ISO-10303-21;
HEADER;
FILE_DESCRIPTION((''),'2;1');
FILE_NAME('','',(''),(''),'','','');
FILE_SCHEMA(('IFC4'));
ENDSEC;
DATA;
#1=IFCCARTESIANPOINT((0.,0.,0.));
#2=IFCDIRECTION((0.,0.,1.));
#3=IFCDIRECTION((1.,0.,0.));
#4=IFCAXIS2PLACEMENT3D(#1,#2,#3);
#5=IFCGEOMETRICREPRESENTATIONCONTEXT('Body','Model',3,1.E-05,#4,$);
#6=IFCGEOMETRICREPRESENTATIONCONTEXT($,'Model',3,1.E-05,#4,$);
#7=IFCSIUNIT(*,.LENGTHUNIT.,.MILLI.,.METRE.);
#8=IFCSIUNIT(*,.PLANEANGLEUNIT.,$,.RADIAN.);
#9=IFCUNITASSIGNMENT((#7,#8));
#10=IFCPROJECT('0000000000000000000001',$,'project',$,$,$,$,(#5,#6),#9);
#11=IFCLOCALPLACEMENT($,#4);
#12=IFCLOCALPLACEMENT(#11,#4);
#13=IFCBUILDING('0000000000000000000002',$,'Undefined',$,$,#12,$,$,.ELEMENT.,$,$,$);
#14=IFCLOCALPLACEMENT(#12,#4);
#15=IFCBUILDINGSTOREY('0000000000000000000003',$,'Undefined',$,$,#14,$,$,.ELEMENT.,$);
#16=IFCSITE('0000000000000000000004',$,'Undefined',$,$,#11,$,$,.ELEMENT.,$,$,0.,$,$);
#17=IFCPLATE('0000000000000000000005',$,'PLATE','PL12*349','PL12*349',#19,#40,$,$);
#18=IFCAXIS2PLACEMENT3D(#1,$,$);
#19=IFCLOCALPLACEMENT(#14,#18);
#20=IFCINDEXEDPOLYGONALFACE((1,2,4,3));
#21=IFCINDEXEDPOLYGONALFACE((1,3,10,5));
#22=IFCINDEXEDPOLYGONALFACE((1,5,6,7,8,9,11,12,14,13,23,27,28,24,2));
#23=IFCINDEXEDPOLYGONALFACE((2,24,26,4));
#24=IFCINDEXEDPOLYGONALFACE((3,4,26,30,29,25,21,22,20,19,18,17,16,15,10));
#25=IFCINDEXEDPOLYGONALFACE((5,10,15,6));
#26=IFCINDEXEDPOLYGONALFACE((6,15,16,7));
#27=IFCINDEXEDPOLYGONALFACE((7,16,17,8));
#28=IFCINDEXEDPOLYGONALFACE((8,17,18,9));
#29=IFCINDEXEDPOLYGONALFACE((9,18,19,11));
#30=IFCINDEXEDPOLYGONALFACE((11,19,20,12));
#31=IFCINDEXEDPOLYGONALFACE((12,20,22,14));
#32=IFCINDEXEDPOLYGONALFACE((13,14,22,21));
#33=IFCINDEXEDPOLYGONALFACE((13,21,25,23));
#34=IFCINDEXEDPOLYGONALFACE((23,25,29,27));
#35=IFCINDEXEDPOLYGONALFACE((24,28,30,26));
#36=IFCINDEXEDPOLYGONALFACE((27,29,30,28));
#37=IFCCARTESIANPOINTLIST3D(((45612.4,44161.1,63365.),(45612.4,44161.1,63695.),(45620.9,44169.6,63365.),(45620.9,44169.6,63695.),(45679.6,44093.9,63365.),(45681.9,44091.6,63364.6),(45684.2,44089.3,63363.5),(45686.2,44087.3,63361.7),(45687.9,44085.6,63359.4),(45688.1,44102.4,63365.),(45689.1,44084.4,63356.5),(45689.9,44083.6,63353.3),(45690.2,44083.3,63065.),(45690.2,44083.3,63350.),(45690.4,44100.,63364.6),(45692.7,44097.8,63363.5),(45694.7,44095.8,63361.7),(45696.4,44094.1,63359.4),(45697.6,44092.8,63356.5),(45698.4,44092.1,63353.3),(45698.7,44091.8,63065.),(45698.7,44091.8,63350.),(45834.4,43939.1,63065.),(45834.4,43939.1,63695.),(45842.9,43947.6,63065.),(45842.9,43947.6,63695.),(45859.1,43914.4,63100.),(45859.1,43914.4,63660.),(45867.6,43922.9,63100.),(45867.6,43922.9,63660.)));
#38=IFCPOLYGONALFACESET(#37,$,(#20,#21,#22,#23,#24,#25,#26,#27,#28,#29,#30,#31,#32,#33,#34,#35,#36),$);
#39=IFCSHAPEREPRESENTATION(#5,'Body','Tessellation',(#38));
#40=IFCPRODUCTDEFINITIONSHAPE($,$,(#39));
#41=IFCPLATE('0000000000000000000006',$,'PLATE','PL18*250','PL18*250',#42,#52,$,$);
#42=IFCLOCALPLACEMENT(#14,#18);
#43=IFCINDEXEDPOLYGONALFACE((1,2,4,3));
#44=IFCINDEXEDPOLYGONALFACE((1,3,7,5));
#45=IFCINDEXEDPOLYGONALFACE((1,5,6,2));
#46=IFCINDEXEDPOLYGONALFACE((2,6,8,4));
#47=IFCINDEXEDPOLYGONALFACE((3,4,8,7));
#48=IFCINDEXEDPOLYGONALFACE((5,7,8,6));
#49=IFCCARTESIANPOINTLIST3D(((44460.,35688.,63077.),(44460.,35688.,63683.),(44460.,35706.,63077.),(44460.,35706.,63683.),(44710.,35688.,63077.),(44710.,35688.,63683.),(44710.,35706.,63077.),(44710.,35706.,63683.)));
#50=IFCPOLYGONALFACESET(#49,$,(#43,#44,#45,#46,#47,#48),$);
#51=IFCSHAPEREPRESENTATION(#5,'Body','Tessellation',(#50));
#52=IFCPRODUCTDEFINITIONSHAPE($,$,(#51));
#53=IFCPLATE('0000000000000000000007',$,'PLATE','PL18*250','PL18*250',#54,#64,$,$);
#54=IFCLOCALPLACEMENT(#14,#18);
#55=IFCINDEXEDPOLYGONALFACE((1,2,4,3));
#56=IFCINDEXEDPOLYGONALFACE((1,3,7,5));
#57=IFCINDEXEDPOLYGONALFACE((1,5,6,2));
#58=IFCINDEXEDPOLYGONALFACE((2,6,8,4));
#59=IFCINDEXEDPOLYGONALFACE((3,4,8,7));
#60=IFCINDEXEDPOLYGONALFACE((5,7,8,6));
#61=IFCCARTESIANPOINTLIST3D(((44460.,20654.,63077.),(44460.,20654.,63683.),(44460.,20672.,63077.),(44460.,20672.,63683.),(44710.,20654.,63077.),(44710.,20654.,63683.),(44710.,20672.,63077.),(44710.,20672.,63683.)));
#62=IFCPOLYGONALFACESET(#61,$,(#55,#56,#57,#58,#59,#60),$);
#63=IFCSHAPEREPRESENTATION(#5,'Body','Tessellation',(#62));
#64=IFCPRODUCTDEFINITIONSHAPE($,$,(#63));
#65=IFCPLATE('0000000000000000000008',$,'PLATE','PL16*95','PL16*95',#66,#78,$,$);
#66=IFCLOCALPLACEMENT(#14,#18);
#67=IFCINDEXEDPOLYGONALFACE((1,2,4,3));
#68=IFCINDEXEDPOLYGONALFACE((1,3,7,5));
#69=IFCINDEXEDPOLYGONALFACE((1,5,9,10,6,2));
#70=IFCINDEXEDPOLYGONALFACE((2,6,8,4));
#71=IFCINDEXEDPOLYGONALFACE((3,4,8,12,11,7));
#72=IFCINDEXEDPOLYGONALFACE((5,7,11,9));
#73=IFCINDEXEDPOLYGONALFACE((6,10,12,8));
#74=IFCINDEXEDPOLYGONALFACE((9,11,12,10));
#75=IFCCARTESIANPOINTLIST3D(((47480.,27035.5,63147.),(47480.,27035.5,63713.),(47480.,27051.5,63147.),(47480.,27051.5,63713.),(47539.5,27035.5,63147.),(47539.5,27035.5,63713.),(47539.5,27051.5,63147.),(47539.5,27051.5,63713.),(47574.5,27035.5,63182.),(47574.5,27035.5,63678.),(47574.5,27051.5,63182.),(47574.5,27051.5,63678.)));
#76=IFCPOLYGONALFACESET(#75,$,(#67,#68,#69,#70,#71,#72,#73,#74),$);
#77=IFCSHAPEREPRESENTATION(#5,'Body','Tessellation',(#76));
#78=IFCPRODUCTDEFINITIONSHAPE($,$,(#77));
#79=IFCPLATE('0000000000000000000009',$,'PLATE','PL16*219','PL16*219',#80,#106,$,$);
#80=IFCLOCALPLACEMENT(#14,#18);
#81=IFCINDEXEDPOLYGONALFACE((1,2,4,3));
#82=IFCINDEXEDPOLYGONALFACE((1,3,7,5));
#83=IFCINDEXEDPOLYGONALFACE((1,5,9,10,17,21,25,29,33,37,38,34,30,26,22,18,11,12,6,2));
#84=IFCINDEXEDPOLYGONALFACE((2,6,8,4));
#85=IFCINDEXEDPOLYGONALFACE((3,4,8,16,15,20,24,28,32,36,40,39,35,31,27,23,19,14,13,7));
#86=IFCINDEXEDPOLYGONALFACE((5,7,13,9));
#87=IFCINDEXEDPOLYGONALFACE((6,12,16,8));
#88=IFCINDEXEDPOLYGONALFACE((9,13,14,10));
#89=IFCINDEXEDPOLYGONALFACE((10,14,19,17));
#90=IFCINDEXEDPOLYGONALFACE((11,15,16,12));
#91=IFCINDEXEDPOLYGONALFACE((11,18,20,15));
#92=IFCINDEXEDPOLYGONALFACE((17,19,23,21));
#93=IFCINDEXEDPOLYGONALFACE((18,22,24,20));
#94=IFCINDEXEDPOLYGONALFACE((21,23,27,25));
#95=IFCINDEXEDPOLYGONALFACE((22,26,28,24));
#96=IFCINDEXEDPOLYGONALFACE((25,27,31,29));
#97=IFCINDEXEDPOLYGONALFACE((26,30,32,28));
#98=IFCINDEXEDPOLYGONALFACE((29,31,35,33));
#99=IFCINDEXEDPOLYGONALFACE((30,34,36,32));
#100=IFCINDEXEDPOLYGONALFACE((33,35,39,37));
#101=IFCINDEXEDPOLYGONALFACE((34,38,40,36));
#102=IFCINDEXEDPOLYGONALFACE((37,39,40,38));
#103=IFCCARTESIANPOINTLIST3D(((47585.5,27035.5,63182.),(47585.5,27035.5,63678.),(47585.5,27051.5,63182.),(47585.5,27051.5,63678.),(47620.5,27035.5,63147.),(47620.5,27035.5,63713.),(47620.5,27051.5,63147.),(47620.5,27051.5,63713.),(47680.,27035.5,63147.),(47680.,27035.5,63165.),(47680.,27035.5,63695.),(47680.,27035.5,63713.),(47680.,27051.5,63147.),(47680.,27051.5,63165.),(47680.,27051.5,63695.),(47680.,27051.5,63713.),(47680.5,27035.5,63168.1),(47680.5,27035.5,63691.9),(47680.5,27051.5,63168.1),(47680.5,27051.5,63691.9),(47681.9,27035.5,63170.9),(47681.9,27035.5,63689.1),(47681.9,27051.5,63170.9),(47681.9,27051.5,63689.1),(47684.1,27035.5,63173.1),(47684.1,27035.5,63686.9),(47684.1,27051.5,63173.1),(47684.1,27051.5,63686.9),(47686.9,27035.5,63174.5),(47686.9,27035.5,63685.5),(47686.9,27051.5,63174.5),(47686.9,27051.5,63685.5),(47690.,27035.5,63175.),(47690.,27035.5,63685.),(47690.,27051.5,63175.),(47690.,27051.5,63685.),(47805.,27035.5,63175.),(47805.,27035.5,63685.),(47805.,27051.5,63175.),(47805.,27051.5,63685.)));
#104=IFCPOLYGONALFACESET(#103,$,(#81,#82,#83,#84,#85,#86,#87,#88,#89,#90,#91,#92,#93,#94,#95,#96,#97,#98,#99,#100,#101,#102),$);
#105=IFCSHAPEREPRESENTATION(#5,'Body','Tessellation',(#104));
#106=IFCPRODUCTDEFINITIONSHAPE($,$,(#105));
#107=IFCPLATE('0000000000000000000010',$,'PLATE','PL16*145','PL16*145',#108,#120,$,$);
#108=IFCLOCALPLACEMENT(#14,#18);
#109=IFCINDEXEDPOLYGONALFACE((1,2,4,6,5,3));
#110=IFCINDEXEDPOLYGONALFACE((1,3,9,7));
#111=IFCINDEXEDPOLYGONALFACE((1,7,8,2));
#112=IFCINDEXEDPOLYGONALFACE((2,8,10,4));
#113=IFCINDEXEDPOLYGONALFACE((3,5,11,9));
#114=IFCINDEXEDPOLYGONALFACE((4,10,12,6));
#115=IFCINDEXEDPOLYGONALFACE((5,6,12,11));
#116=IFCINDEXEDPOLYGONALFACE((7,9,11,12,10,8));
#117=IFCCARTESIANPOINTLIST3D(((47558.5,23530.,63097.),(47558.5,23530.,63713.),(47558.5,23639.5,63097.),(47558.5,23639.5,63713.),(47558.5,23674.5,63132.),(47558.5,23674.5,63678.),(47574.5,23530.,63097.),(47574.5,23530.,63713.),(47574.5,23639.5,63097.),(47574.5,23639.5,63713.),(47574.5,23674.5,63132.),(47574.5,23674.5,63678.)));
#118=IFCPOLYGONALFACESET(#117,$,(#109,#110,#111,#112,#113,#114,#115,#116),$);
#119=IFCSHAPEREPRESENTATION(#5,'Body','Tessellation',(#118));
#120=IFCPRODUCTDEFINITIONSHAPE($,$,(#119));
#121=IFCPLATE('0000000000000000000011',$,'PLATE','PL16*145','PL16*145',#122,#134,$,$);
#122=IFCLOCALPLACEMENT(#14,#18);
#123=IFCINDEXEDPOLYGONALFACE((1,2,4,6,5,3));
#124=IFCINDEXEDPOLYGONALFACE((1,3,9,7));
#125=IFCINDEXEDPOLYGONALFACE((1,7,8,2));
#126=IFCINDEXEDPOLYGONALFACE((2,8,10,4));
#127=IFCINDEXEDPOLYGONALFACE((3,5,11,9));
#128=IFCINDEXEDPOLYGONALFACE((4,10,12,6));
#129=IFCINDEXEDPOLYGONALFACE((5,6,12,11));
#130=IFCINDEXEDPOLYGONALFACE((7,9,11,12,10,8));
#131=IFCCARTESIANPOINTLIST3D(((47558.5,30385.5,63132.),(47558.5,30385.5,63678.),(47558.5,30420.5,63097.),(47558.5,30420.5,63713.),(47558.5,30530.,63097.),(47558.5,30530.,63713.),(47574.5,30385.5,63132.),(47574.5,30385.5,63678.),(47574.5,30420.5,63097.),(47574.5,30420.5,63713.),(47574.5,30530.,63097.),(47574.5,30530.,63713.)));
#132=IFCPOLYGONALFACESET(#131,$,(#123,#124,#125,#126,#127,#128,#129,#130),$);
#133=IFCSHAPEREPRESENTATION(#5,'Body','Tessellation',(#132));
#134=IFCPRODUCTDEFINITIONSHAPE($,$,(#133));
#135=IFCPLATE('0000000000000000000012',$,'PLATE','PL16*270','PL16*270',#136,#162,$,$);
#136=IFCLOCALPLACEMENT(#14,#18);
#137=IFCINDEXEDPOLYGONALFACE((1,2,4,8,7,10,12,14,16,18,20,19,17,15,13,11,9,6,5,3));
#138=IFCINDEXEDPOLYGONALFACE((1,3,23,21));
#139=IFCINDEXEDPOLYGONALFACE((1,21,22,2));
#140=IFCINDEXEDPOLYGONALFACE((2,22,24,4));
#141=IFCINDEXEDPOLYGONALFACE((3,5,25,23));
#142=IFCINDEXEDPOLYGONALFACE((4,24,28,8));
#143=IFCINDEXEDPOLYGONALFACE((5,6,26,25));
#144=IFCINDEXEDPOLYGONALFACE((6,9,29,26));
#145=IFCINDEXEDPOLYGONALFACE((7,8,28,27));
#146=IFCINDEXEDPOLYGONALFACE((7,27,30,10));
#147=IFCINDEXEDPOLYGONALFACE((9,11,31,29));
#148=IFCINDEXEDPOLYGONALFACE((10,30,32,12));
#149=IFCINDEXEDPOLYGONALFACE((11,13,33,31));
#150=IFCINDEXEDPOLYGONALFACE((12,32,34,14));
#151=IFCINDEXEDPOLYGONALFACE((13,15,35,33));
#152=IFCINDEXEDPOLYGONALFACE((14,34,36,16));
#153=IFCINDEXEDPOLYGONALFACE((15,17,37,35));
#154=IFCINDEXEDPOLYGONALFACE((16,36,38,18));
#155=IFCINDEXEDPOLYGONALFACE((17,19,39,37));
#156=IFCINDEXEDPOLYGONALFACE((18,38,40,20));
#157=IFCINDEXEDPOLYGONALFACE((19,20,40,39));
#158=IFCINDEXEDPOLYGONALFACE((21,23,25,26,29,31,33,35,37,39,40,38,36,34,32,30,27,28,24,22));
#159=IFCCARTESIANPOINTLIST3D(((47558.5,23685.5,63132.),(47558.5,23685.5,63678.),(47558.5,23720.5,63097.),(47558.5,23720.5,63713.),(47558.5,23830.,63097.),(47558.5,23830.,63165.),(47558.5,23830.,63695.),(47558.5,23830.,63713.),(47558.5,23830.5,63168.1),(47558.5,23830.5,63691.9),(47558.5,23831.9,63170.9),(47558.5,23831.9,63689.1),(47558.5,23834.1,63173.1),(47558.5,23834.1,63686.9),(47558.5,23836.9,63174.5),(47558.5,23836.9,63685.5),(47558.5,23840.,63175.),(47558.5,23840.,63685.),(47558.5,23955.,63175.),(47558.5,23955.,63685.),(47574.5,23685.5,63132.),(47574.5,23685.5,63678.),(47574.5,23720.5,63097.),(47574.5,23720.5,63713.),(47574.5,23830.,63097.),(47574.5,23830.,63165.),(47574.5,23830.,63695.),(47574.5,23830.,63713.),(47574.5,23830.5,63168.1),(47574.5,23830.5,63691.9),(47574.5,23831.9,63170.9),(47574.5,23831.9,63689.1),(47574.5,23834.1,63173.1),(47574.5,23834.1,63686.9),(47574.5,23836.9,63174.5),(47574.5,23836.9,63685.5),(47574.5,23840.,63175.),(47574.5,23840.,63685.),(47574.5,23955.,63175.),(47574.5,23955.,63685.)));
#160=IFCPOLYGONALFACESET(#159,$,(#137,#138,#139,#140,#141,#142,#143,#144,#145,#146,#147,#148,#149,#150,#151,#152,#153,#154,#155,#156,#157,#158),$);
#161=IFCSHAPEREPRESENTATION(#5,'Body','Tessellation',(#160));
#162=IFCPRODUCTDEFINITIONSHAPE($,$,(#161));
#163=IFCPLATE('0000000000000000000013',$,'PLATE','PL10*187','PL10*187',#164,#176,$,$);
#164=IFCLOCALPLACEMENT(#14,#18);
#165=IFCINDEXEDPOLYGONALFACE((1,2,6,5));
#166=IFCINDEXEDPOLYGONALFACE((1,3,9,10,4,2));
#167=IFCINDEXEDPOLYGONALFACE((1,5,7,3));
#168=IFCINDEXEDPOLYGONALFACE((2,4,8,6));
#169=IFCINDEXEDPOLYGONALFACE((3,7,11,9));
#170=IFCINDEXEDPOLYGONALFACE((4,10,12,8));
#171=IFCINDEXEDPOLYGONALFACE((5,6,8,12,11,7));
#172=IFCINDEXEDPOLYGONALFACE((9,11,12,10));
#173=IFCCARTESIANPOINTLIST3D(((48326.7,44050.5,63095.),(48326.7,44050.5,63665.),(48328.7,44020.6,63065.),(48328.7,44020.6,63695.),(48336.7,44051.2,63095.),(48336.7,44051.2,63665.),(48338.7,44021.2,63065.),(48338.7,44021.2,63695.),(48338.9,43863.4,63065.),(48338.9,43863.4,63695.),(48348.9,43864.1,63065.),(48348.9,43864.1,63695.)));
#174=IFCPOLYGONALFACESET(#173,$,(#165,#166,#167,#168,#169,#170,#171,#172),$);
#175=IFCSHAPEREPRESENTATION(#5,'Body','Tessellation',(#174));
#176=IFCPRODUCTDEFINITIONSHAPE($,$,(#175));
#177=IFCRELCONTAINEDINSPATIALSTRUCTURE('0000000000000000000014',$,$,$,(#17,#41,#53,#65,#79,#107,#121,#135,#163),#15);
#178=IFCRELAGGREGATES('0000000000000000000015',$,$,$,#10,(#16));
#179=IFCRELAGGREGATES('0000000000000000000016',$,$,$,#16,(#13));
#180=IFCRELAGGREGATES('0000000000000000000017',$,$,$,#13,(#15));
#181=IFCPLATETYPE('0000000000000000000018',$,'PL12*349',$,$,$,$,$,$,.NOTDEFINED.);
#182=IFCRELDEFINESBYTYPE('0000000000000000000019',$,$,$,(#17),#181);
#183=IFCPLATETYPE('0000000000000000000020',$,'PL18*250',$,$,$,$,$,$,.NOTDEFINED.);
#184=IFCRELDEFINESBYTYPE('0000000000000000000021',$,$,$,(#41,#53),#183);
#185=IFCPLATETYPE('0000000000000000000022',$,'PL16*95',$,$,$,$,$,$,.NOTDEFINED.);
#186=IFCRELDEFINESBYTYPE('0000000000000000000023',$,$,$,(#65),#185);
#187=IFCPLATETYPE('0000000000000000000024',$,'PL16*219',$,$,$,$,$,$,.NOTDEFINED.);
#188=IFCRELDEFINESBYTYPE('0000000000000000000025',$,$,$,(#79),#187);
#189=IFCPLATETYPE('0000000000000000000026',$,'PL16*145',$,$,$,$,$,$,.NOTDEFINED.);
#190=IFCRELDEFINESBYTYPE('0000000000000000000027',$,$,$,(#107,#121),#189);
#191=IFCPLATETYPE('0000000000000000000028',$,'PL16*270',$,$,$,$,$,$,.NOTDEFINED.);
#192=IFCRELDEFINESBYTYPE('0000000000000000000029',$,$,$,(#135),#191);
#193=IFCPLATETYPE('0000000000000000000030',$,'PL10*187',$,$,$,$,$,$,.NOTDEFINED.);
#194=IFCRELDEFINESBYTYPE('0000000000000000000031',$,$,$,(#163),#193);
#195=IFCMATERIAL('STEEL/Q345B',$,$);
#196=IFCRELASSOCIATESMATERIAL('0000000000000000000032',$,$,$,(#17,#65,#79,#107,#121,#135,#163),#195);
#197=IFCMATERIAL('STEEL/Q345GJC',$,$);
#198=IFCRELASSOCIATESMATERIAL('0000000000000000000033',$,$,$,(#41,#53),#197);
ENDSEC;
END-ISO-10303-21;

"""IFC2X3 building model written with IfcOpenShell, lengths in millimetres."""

from ifc_helpers import new_model, si_unit, frame, origin_with_axes, place, context, project, spatial, polyline, outline, extrude, material, type_object, element, save


model = new_model("IFC2X3")

# Units and contexts
model_context_1 = context("Model", 3, precision=1e-05, world=origin_with_axes(), identifier="Body")
model_context_2 = context("Model", 3, precision=1e-05, world=origin_with_axes())
ifc_project = project(units=[si_unit("LENGTHUNIT", "METRE", prefix="MILLI"), si_unit("PLANEANGLEUNIT", "RADIAN")], contexts=[model_context_1, model_context_2])

# Site, building, storey
site_placement = place(None, origin_with_axes())
site = spatial("IfcSite", under=ifc_project, at=site_placement, Name="Undefined", CompositionType="ELEMENT", RefElevation=0.0)
building_placement = place(site_placement, origin_with_axes())
building = spatial("IfcBuilding", under=site, at=building_placement, Name="Undefined", CompositionType="ELEMENT")
storey_placement = place(building_placement, origin_with_axes())
storey = spatial("IfcBuildingStorey", under=building, at=storey_placement, Name="Undefined", CompositionType="ELEMENT")

# Shared definitions
ifc_material_1 = material(Name="STEEL/Q345B")
ifc_material_2 = material(Name="STEEL/Q345GJC")

# Plates
plate_type_1 = type_object("IfcPlateType", Name="PL12*349", PredefinedType="NOTDEFINED")
plate_1_placement = place(storey_placement, frame((45616.6, 44165.4, 63695.0), z_axis=(-0.707107, -0.707107, 0.0), x_axis=(0.0, 0.0, -1.0)))
element("IfcPlate", 1, at=plate_1_placement, inside=storey, type_object=plate_type_1, material=ifc_material_1, Name="PLATE", Description="PL12*349", ObjectType="PL12*349", context=model_context_1, shape_type="SweptSolid", body=[
    extrude(outline(polyline([(0.0, 0.0), (330.0, 0.0), (330.0, 95.0), (330.4, 98.4), (331.5, 101.5), (333.3, 104.4), (335.6, 106.8), (338.5, 108.5), (341.7, 109.7), (345.0, 110.0), (630.0, 110.0), (630.0, 313.9), (595.0, 348.9), (35.0, 348.9), (0.0, 313.9), (0.0, 0.0)])), frame((0.0, 0.0, -6.0), z_axis=(0.0, 0.0, 1.0), x_axis=(1.0, 0.0, 0.0)), (0.0, 0.0, 1.0), 12.0),
])
plate_type_2 = type_object("IfcPlateType", Name="PL18*250", PredefinedType="NOTDEFINED")
for number, where, z_axis, x_axis, name in (
    (2, (44710.0, 35697.0, 63683.0), (0.0, -1.0, 0.0), (-1.0, 0.0, 0.0), "PLATE"),
    (3, (44710.0, 20663.0, 63683.0), (0.0, -1.0, 0.0), (-1.0, 0.0, 0.0), "PLATE"),
):
    element("IfcPlate", number, at=place(storey_placement, frame(where, z_axis=z_axis, x_axis=x_axis)), inside=storey, type_object=plate_type_2, material=ifc_material_2, Name=name, Description="PL18*250", ObjectType="PL18*250", context=model_context_1, shape_type="SweptSolid", body=[
        extrude(outline(polyline([(0.0, 0.0), (250.0, 0.0), (250.0, 606.0), (0.0, 606.0), (0.0, 0.0)])), frame((0.0, 0.0, -9.0), z_axis=(0.0, 0.0, 1.0), x_axis=(1.0, 0.0, 0.0)), (0.0, 0.0, 1.0), 18.0),
    ])
plate_type_3 = type_object("IfcPlateType", Name="PL16*95", PredefinedType="NOTDEFINED")
plate_2_placement = place(storey_placement, frame((47574.5, 27043.5, 63147.0), z_axis=(0.0, 1.0, 0.0), x_axis=(-1.0, 0.0, 0.0)))
element("IfcPlate", 4, at=plate_2_placement, inside=storey, type_object=plate_type_3, material=ifc_material_1, Name="PLATE", Description="PL16*95", ObjectType="PL16*95", context=model_context_1, shape_type="SweptSolid", body=[
    extrude(outline(polyline([(0.0, 35.0), (35.0, 0.0), (94.5, 0.0), (94.5, 566.0), (35.0, 566.0), (0.0, 531.0), (0.0, 35.0)])), frame((0.0, 0.0, -8.0), z_axis=(0.0, 0.0, 1.0), x_axis=(1.0, 0.0, 0.0)), (0.0, 0.0, 1.0), 16.0),
])
plate_type_4 = type_object("IfcPlateType", Name="PL16*219", PredefinedType="NOTDEFINED")
plate_3_placement = place(storey_placement, frame((47585.5, 27043.5, 63182.0), z_axis=(0.0, -1.0, 0.0), x_axis=(0.707107, 0.0, -0.707107)))
element("IfcPlate", 5, at=plate_3_placement, inside=storey, type_object=plate_type_4, material=ifc_material_1, Name="PLATE", Description="PL16*219", ObjectType="PL16*219", context=model_context_1, shape_type="SweptSolid", body=[
    extrude(outline(polyline([(0.0, 0.0), (49.5, 0.0), (91.6, 42.1), (78.8, 54.8), (77.0, 57.3), (76.0, 60.3), (76.0, 63.4), (77.0, 66.4), (78.8, 68.9), (160.2, 150.3), (-200.5, 510.9), (-281.8, 429.6), (-284.3, 427.7), (-287.3, 426.8), (-290.4, 426.8), (-293.4, 427.7), (-295.9, 429.6), (-308.7, 442.3), (-350.7, 400.2), (-350.7, 350.7), (0.0, 0.0)])), frame((0.0, 0.0, -8.0), z_axis=(0.0, 0.0, 1.0), x_axis=(1.0, 0.0, 0.0)), (0.0, 0.0, 1.0), 16.0),
])
plate_type_5 = type_object("IfcPlateType", Name="PL16*145", PredefinedType="NOTDEFINED")
for number, where, z_axis, x_axis, name in (
    (6, (47566.5, 23674.5, 63097.0), (-1.0, 0.0, 0.0), (0.0, -1.0, 0.0), "PLATE"),
    (7, (47566.5, 30385.5, 63097.0), (1.0, 0.0, 0.0), (0.0, 1.0, 0.0), "PLATE"),
):
    element("IfcPlate", number, at=place(storey_placement, frame(where, z_axis=z_axis, x_axis=x_axis)), inside=storey, type_object=plate_type_5, material=ifc_material_1, Name=name, Description="PL16*145", ObjectType="PL16*145", context=model_context_1, shape_type="SweptSolid", body=[
        extrude(outline(polyline([(0.0, 35.0), (35.0, 0.0), (144.5, 0.0), (144.5, 616.0), (35.0, 616.0), (0.0, 581.0), (0.0, 35.0)])), frame((0.0, 0.0, -8.0), z_axis=(0.0, 0.0, 1.0), x_axis=(1.0, 0.0, 0.0)), (0.0, 0.0, 1.0), 16.0),
    ])
plate_type_6 = type_object("IfcPlateType", Name="PL16*270", PredefinedType="NOTDEFINED")
for number, where, z_axis, x_axis, name in (
    (8, (47566.5, 23685.5, 63132.0), (1.0, 0.0, 0.0), (0.0, 0.707107, -0.707107), "PLATE"),
):
    element("IfcPlate", number, at=place(storey_placement, frame(where, z_axis=z_axis, x_axis=x_axis)), inside=storey, type_object=plate_type_6, material=ifc_material_1, Name=name, Description="PL16*270", ObjectType="PL16*270", context=model_context_1, shape_type="SweptSolid", body=[
        extrude(outline(polyline([(0.0, 0.0), (49.5, 0.0), (126.9, 77.4), (78.8, 125.5), (77.0, 128.0), (76.0, 131.0), (76.0, 134.1), (77.0, 137.1), (78.8, 139.7), (160.2, 221.0), (-200.5, 581.6), (-281.8, 500.3), (-284.3, 498.4), (-287.3, 497.5), (-290.4, 497.5), (-293.4, 498.4), (-295.9, 500.3), (-308.7, 513.0), (-386.1, 435.6), (-386.1, 386.1), (0.0, 0.0)])), frame((0.0, 0.0, -8.0), z_axis=(0.0, 0.0, 1.0), x_axis=(1.0, 0.0, 0.0)), (0.0, 0.0, 1.0), 16.0),
    ])
plate_type_7 = type_object("IfcPlateType", Name="PL10*187", PredefinedType="NOTDEFINED")
plate_4_placement = place(storey_placement, frame((48331.7, 44050.8, 63065.0), z_axis=(-0.997873, -0.065183, 0.0), x_axis=(0.065183, -0.997873, 0.0)))
element("IfcPlate", 9, at=plate_4_placement, inside=storey, type_object=plate_type_7, material=ifc_material_1, Name="PLATE", Description="PL10*187", ObjectType="PL10*187", context=model_context_1, shape_type="SweptSolid", body=[
    extrude(outline(polyline([(0.0, 30.0), (30.0, 0.0), (187.5, 0.0), (187.5, 630.0), (30.0, 630.0), (0.0, 600.0), (0.0, 30.0)])), frame((0.0, 0.0, -5.0), z_axis=(0.0, 0.0, 1.0), x_axis=(1.0, 0.0, 0.0)), (0.0, 0.0, 1.0), 10.0),
])

save(model, "model.ifc")
